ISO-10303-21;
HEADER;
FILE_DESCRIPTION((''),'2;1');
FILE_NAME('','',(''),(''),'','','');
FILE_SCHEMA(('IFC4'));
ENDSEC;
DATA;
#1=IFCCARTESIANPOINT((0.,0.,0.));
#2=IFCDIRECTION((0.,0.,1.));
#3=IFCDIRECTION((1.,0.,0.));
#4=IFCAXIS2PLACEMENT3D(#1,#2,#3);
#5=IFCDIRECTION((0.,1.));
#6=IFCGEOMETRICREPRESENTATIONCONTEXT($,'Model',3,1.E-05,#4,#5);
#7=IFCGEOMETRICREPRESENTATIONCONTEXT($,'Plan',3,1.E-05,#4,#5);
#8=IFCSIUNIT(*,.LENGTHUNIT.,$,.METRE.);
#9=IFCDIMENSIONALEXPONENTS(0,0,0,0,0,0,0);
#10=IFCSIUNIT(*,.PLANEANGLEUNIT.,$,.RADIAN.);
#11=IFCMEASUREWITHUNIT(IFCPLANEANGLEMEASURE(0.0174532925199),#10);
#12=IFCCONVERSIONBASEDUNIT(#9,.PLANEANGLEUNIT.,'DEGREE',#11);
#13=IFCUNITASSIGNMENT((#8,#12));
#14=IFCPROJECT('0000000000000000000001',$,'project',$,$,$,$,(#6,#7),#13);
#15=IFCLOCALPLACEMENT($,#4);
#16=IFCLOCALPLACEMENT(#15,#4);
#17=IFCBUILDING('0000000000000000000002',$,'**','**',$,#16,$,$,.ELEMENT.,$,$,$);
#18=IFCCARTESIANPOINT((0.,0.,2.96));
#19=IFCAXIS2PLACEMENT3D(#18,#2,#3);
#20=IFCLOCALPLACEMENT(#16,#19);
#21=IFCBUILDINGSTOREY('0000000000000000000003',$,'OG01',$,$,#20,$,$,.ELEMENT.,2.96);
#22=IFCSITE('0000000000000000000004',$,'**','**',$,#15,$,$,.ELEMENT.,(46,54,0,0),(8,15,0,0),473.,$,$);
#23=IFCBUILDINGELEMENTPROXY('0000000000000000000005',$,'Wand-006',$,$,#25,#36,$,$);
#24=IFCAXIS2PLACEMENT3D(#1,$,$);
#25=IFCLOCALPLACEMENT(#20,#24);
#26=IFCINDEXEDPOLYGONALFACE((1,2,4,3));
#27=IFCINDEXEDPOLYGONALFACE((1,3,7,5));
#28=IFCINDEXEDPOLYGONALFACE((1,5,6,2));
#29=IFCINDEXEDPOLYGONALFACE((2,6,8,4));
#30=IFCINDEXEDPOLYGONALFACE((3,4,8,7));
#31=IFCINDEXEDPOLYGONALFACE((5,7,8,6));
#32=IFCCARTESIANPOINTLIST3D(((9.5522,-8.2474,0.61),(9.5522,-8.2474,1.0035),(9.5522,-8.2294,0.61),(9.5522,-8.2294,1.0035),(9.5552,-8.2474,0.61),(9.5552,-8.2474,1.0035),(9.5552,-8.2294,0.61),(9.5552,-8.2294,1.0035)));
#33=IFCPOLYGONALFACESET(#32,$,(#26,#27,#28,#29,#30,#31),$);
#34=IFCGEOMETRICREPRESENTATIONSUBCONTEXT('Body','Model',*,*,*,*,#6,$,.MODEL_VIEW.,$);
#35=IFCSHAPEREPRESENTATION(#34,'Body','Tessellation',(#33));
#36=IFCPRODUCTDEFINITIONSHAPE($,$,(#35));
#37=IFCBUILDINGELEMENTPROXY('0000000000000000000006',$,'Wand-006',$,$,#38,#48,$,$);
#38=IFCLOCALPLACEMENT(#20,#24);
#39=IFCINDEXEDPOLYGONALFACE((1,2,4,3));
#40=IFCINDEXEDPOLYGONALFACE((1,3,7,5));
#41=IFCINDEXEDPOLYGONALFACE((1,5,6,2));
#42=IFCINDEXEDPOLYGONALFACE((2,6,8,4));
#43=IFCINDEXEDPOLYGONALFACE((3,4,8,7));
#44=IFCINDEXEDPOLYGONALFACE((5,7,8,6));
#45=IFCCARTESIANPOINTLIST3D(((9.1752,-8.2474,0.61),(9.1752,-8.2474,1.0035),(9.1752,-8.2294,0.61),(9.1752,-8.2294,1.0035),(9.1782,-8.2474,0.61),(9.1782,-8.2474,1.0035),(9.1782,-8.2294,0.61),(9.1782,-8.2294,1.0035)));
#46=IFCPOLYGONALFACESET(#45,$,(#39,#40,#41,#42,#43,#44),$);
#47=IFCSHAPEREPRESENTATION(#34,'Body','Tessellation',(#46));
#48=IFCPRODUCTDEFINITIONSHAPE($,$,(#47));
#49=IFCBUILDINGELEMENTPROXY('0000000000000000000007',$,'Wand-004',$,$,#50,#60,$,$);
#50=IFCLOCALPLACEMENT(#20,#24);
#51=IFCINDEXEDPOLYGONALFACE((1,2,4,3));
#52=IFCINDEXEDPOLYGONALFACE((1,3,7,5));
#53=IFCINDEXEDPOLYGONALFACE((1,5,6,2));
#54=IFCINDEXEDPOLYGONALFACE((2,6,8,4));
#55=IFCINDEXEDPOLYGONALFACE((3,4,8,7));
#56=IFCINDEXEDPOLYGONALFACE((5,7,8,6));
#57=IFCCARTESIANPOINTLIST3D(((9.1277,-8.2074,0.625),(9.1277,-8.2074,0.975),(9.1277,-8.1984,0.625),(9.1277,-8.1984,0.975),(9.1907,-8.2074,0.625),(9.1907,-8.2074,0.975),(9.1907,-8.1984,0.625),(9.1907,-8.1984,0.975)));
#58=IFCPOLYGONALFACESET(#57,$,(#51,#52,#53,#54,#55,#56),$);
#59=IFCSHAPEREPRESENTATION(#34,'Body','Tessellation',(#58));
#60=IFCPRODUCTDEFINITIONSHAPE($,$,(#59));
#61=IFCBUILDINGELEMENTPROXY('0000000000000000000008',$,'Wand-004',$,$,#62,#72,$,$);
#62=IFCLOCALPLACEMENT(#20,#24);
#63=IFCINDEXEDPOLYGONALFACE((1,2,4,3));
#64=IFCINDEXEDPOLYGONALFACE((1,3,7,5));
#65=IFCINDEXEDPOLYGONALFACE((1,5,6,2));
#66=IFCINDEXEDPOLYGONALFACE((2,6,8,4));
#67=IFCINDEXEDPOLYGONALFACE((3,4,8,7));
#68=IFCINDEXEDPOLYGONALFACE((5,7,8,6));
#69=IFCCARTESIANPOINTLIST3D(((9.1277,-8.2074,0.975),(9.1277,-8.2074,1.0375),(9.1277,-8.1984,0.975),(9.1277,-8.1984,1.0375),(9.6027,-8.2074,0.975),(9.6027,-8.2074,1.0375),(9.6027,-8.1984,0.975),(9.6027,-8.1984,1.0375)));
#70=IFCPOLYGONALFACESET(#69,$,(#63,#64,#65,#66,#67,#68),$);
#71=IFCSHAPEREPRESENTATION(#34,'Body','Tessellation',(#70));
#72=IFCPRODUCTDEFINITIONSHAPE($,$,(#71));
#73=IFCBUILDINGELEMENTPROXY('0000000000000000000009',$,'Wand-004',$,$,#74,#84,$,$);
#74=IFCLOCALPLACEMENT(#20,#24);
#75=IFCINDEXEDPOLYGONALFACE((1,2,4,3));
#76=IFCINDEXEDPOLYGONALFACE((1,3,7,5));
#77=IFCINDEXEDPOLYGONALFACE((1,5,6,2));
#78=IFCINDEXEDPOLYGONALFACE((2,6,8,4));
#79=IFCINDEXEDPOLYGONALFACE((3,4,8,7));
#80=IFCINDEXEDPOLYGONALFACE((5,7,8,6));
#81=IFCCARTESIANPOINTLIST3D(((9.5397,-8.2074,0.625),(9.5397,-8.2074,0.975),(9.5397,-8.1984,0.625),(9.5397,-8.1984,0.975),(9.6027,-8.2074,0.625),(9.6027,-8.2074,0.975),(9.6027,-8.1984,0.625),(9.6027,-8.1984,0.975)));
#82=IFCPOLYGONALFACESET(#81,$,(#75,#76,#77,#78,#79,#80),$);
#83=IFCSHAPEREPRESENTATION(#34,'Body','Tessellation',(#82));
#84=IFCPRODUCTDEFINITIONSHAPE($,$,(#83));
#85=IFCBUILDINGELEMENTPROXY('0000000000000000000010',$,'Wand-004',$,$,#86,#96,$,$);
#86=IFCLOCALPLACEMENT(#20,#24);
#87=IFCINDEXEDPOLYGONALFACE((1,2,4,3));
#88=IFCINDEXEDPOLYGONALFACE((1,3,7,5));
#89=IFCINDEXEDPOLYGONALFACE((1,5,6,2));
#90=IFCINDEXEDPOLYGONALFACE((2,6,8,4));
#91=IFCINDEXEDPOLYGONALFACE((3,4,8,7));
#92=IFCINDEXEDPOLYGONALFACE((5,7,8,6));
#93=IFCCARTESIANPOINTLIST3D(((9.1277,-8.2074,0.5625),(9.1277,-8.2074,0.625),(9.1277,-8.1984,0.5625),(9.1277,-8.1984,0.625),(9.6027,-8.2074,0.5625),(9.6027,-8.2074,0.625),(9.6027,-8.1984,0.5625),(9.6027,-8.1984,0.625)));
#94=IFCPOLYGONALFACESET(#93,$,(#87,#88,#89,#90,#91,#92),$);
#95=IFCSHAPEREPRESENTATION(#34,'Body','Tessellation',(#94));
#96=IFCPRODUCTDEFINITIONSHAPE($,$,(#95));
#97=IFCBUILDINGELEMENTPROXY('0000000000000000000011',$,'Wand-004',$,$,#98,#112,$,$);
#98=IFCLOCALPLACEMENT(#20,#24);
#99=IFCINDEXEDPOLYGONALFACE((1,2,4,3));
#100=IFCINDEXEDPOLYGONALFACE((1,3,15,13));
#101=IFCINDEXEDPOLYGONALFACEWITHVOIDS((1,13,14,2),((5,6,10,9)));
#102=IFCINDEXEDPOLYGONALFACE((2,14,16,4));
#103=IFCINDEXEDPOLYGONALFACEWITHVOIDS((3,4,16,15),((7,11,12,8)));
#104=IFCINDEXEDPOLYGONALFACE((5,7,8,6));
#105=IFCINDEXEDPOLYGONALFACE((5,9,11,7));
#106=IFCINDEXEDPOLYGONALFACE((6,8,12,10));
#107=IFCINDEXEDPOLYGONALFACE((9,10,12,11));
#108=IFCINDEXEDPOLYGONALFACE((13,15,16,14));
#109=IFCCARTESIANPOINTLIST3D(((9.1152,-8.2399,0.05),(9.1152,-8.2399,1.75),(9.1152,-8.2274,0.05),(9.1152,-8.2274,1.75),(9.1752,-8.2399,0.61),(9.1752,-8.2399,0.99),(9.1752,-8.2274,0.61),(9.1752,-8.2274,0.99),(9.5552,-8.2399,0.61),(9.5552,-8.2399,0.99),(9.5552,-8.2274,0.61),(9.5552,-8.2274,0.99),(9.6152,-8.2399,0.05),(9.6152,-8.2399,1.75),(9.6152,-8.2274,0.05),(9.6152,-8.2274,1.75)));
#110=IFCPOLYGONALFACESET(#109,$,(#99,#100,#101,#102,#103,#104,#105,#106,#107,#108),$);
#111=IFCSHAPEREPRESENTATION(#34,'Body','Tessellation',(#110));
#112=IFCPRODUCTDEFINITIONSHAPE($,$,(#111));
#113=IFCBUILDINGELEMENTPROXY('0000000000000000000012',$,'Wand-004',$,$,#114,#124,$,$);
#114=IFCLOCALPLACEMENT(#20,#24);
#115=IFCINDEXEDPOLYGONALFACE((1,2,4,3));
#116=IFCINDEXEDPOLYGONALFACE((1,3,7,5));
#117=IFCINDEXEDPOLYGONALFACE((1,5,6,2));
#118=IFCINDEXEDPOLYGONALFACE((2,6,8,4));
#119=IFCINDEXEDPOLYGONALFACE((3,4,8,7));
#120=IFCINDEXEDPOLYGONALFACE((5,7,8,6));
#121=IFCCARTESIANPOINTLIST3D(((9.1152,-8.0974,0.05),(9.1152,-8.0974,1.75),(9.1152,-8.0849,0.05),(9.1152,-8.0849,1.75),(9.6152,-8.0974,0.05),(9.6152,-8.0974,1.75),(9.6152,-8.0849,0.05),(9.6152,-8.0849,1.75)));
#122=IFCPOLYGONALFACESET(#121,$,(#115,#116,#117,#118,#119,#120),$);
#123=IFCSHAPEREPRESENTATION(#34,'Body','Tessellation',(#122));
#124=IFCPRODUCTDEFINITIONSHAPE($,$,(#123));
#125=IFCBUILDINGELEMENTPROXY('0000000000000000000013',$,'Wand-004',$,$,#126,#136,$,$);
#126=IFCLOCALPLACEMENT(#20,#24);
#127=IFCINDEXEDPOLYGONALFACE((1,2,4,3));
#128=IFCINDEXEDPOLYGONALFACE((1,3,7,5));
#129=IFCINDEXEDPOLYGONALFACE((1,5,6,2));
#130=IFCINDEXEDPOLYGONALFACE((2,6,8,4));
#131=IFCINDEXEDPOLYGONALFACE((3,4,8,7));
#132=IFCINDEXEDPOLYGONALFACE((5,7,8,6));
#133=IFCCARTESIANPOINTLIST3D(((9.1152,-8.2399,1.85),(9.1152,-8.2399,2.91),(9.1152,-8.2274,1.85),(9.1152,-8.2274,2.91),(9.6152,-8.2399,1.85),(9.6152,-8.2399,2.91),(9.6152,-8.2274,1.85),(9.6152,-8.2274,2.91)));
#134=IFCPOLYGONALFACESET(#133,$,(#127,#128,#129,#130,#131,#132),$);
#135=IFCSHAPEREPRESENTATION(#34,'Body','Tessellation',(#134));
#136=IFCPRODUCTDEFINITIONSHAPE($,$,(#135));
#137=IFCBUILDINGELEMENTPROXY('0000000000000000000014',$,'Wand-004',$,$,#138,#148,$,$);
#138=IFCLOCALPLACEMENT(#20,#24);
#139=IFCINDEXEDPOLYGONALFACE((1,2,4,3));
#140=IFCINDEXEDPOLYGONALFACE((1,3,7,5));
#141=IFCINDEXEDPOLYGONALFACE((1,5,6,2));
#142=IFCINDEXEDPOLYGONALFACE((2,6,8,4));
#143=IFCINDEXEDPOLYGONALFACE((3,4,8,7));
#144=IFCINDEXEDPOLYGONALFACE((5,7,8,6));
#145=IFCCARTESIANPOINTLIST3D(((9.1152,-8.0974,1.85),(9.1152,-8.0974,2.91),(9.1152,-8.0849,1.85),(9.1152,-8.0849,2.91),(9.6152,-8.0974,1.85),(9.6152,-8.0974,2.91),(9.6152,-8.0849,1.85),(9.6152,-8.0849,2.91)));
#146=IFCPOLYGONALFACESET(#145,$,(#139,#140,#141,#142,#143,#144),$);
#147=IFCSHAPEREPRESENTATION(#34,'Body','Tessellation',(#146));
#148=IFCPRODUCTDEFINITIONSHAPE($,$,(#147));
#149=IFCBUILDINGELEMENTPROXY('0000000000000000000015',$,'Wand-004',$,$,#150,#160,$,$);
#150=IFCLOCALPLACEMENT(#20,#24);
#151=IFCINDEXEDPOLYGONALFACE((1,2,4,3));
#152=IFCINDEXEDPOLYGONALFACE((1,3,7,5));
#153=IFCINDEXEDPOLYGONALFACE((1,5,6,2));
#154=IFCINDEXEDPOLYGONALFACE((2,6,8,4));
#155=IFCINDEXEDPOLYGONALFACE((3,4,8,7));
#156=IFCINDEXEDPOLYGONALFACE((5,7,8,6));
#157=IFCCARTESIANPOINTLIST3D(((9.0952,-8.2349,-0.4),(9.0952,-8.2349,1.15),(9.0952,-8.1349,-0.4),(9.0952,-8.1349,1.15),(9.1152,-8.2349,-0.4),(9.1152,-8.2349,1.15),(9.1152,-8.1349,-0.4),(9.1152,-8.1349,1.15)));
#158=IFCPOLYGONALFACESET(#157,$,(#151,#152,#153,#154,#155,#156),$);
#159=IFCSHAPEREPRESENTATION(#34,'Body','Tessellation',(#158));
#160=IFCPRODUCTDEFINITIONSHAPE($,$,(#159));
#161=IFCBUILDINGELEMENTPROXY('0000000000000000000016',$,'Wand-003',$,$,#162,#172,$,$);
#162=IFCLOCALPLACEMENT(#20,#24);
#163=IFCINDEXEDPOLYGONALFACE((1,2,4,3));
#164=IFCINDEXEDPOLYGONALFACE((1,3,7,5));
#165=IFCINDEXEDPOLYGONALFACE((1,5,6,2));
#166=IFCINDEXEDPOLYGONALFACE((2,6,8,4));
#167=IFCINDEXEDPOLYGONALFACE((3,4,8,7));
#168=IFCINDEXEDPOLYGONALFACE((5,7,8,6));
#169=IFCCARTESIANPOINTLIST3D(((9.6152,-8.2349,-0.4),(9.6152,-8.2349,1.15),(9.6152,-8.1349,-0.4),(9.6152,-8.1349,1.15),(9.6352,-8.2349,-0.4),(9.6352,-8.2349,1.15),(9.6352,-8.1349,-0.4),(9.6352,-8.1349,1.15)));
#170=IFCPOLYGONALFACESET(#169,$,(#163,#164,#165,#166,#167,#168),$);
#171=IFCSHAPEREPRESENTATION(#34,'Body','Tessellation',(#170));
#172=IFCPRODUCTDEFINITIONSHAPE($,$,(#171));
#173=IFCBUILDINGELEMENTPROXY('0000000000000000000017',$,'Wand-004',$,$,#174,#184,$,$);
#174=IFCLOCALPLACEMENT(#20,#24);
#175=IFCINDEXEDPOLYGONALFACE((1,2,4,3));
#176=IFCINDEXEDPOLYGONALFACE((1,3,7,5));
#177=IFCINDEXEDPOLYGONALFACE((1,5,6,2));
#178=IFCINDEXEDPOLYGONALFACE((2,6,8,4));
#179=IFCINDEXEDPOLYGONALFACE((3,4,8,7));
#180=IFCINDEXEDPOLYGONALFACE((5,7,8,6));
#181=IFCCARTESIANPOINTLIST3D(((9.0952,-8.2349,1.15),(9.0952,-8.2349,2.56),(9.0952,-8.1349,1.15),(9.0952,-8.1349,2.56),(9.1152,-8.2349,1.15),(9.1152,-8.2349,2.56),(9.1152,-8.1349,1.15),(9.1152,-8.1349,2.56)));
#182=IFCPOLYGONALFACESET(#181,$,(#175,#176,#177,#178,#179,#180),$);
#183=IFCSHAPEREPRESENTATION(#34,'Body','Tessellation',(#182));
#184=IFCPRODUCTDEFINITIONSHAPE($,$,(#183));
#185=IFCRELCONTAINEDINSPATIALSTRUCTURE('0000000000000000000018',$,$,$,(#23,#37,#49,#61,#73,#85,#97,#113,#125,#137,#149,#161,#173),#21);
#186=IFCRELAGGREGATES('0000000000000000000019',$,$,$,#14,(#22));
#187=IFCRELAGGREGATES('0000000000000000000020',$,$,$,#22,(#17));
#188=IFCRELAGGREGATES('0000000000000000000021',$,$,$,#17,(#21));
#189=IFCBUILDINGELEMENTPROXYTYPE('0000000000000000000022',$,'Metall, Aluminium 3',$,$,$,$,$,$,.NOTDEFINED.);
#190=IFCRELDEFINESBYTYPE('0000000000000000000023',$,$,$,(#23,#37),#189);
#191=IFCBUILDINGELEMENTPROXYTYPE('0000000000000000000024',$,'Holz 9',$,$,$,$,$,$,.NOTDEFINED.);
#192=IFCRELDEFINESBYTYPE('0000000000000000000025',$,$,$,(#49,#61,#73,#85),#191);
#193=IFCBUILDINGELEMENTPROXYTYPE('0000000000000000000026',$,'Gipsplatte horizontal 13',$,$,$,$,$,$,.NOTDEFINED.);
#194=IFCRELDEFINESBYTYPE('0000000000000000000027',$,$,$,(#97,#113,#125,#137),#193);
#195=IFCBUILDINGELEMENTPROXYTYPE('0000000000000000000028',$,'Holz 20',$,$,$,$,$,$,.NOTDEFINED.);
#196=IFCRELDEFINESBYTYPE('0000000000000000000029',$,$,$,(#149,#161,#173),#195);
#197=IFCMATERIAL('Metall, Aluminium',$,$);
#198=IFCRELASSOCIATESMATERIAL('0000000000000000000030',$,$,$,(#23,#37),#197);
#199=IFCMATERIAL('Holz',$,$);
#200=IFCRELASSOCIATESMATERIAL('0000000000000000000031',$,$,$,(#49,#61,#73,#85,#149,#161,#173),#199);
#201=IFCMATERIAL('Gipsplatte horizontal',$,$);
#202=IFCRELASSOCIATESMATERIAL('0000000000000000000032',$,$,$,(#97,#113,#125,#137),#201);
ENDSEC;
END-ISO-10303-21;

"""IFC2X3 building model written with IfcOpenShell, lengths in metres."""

from ifc_helpers import new_model, entity, si_unit, converted_unit, direction, frame, origin_with_axes, origin_2d_with_axis, place, context, subcontext, project, spatial, polyline, rectangle, outline, extrude, material, type_object, element, save


model = new_model("IFC2X3")

# Units and contexts
model_context = context("Model", 3, precision=1e-05, world=origin_with_axes(), true_north=direction((0.0, 1.0)))
plan_context = context("Plan", 3, precision=1e-05, world=origin_with_axes(), true_north=direction((0.0, 1.0)))
body_context = subcontext(model_context, "Body", "Model", "MODEL_VIEW")
ifc_project = project(units=[si_unit("LENGTHUNIT", "METRE"), converted_unit("PLANEANGLEUNIT", "DEGREE", entity("IfcPlaneAngleMeasure", 0.0174532925199), si_unit("PLANEANGLEUNIT", "RADIAN"), dimensions=[0, 0, 0, 0, 0, 0, 0])], contexts=[model_context, plan_context])

# Site, building, storey
site_placement = place(None, origin_with_axes())
site = spatial("IfcSite", under=ifc_project, at=site_placement, Name="**", Description="**", CompositionType="ELEMENT", RefLatitude=(46, 54, 0, 0), RefLongitude=(8, 15, 0, 0), RefElevation=473.0)
building_placement = place(site_placement, origin_with_axes())
building = spatial("IfcBuilding", under=site, at=building_placement, Name="**", Description="**", CompositionType="ELEMENT")
storey_placement = place(building_placement, frame((0.0, 0.0, 2.96), z_axis=(0.0, 0.0, 1.0), x_axis=(1.0, 0.0, 0.0)))
storey = spatial("IfcBuildingStorey", under=building, at=storey_placement, Name="OG01", CompositionType="ELEMENT", Elevation=2.96)

# Building element proxies
ifc_material_1 = material(Name="Holz")
ifc_material_2 = material(Name="Metall, Aluminium")
building_element_proxy_type_1 = type_object("IfcBuildingElementProxyType", Name="Metall, Aluminium 3", PredefinedType="NOTDEFINED")
proxy_1_placement = place(storey_placement, frame((9.5552, -8.2294, 0.61), z_axis=(0.0, 0.0, 1.0), x_axis=(0.0, -1.0, 0.0)))
element("IfcBuildingElementProxy", 1, at=proxy_1_placement, inside=storey, type_object=building_element_proxy_type_1, material=ifc_material_2, Name="Wand-006", context=body_context, shape_type="SweptSolid", body=[
    extrude(outline(polyline([(0.0, -0.003), (0.018, -0.003), (0.018, 0.0), (0.0, 0.0), (0.0, -0.003)])), origin_with_axes(), (0.0, 0.0, 1.0), 0.3935),
])
proxy_2_placement = place(storey_placement, frame((9.1752, -8.2294, 0.61), z_axis=(0.0, 0.0, 1.0), x_axis=(0.0, -1.0, 0.0)))
element("IfcBuildingElementProxy", 2, at=proxy_2_placement, inside=storey, type_object=building_element_proxy_type_1, material=ifc_material_2, Name="Wand-006", context=body_context, shape_type="SweptSolid", body=[
    extrude(outline(polyline([(0.0, 0.0), (0.018, 0.0), (0.018, 0.003), (0.0, 0.003), (0.0, 0.0)])), origin_with_axes(), (0.0, 0.0, 1.0), 0.3935),
])
building_element_proxy_type_2 = type_object("IfcBuildingElementProxyType", Name="Holz 9", PredefinedType="NOTDEFINED")
proxy_3_placement = place(storey_placement, frame((9.1277, -8.2074, 0.625), z_axis=(0.0, 0.0, 1.0), x_axis=(1.0, 0.0, 0.0)))
element("IfcBuildingElementProxy", 3, at=proxy_3_placement, inside=storey, type_object=building_element_proxy_type_2, material=ifc_material_1, Name="Wand-004", context=body_context, shape_type="SweptSolid", body=[
    extrude(outline(polyline([(0.0, 0.0), (0.063, 0.0), (0.063, 0.009), (0.0, 0.009), (0.0, 0.0)])), origin_with_axes(), (0.0, 0.0, 1.0), 0.35),
])
proxy_4_placement = place(storey_placement, frame((9.6027, -8.2074, 0.975), z_axis=(0.0, 0.0, 1.0), x_axis=(-1.0, 0.0, 0.0)))
element("IfcBuildingElementProxy", 4, at=proxy_4_placement, inside=storey, type_object=building_element_proxy_type_2, material=ifc_material_1, Name="Wand-004", context=body_context, shape_type="SweptSolid", body=[
    extrude(outline(polyline([(0.0, -0.009), (0.475, -0.009), (0.475, 0.0), (0.0, 0.0), (0.0, -0.009)])), origin_with_axes(), (0.0, 0.0, 1.0), 0.0625),
])
proxy_5_placement = place(storey_placement, frame((9.5397, -8.2074, 0.625), z_axis=(0.0, 0.0, 1.0), x_axis=(1.0, 0.0, 0.0)))
element("IfcBuildingElementProxy", 5, at=proxy_5_placement, inside=storey, type_object=building_element_proxy_type_2, material=ifc_material_1, Name="Wand-004", context=body_context, shape_type="SweptSolid", body=[
    extrude(outline(polyline([(0.0, 0.0), (0.063, 0.0), (0.063, 0.009), (0.0, 0.009), (0.0, 0.0)])), origin_with_axes(), (0.0, 0.0, 1.0), 0.35),
])
proxy_6_placement = place(storey_placement, frame((9.6027, -8.2074, 0.5625), z_axis=(0.0, 0.0, 1.0), x_axis=(-1.0, 0.0, 0.0)))
element("IfcBuildingElementProxy", 6, at=proxy_6_placement, inside=storey, type_object=building_element_proxy_type_2, material=ifc_material_1, Name="Wand-004", context=body_context, shape_type="SweptSolid", body=[
    extrude(outline(polyline([(0.0, -0.009), (0.475, -0.009), (0.475, 0.0), (0.0, 0.0), (0.0, -0.009)])), origin_with_axes(), (0.0, 0.0, 1.0), 0.0625),
])

# Building element proxy, opening
ifc_material_3 = material(Name="Gipsplatte horizontal")
building_element_proxy_type_3 = type_object("IfcBuildingElementProxyType", Name="Gipsplatte horizontal 13", PredefinedType="NOTDEFINED")
proxy_7_placement = place(storey_placement, frame((9.1152, -8.2399, 0.05), z_axis=(0.0, 0.0, 1.0), x_axis=(1.0, 0.0, 0.0)))
proxy_7 = element("IfcBuildingElementProxy", 7, at=proxy_7_placement, inside=storey, type_object=building_element_proxy_type_3, material=ifc_material_3, Name="Wand-004", context=body_context, shape_type="SweptSolid", body=[
    extrude(outline(polyline([(0.0, 0.0), (0.5, 0.0), (0.5, 0.0125), (0.0, 0.0125), (0.0, 0.0)])), origin_with_axes(), (0.0, 0.0, 1.0), 1.7),
])
opening_placement = place(proxy_7_placement, frame((-9.1152, 8.2399, -3.01), z_axis=(0.0, 0.0, 1.0), x_axis=(1.0, 0.0, 0.0)))
element("IfcOpeningElement", 8, at=opening_placement, cuts=proxy_7, context=body_context, shape_type="SweptSolid", body=[
    extrude(rectangle(XDim=0.38, YDim=0.38, at=origin_2d_with_axis()), frame((9.3652, -8.2524, 3.76), z_axis=(0.0, -1.0, 0.0), x_axis=(1.0, 0.0, 0.0)), (0.0, 0.0, -1.0), 0.0375),
])

# Building element proxies
proxy_8_placement = place(storey_placement, frame((9.1152, -8.0849, 0.05), z_axis=(0.0, 0.0, 1.0), x_axis=(1.0, 0.0, 0.0)))
element("IfcBuildingElementProxy", 9, at=proxy_8_placement, inside=storey, type_object=building_element_proxy_type_3, material=ifc_material_3, Name="Wand-004", context=body_context, shape_type="SweptSolid", body=[
    extrude(outline(polyline([(0.0, -0.0125), (0.5, -0.0125), (0.5, 0.0), (0.0, 0.0), (0.0, -0.0125)])), origin_with_axes(), (0.0, 0.0, 1.0), 1.7),
])
proxy_9_placement = place(storey_placement, frame((9.1152, -8.2399, 1.85), z_axis=(0.0, 0.0, 1.0), x_axis=(1.0, 0.0, 0.0)))
element("IfcBuildingElementProxy", 10, at=proxy_9_placement, inside=storey, type_object=building_element_proxy_type_3, material=ifc_material_3, Name="Wand-004", context=body_context, shape_type="SweptSolid", body=[
    extrude(outline(polyline([(0.0, 0.0), (0.5, 0.0), (0.5, 0.0125), (0.0, 0.0125), (0.0, 0.0)])), origin_with_axes(), (0.0, 0.0, 1.0), 1.06),
])
proxy_10_placement = place(storey_placement, frame((9.1152, -8.0849, 1.85), z_axis=(0.0, 0.0, 1.0), x_axis=(1.0, 0.0, 0.0)))
element("IfcBuildingElementProxy", 11, at=proxy_10_placement, inside=storey, type_object=building_element_proxy_type_3, material=ifc_material_3, Name="Wand-004", context=body_context, shape_type="SweptSolid", body=[
    extrude(outline(polyline([(0.0, -0.0125), (0.5, -0.0125), (0.5, 0.0), (0.0, 0.0), (0.0, -0.0125)])), origin_with_axes(), (0.0, 0.0, 1.0), 1.06),
])
building_element_proxy_type_4 = type_object("IfcBuildingElementProxyType", Name="Holz 20", PredefinedType="NOTDEFINED")
proxy_11_placement = place(storey_placement, frame((9.0952, -8.1349, -0.4), z_axis=(0.0, 0.0, 1.0), x_axis=(0.0, -1.0, 0.0)))
element("IfcBuildingElementProxy", 12, at=proxy_11_placement, inside=storey, type_object=building_element_proxy_type_4, material=ifc_material_1, Name="Wand-004", context=body_context, shape_type="SweptSolid", body=[
    extrude(outline(polyline([(0.0, 0.0), (0.1, 0.0), (0.1, 0.02), (0.0, 0.02), (0.0, 0.0)])), origin_with_axes(), (0.0, 0.0, 1.0), 1.55),
])
proxy_12_placement = place(storey_placement, frame((9.6352, -8.1349, -0.4), z_axis=(0.0, 0.0, 1.0), x_axis=(0.0, -1.0, 0.0)))
element("IfcBuildingElementProxy", 13, at=proxy_12_placement, inside=storey, type_object=building_element_proxy_type_4, material=ifc_material_1, Name="Wand-003", context=body_context, shape_type="SweptSolid", body=[
    extrude(outline(polyline([(0.0, -0.02), (0.1, -0.02), (0.1, 0.0), (0.0, 0.0), (0.0, -0.02)])), origin_with_axes(), (0.0, 0.0, 1.0), 1.55),
])
proxy_13_placement = place(storey_placement, frame((9.0952, -8.1349, 1.15), z_axis=(0.0, 0.0, 1.0), x_axis=(0.0, -1.0, 0.0)))
element("IfcBuildingElementProxy", 14, at=proxy_13_placement, inside=storey, type_object=building_element_proxy_type_4, material=ifc_material_1, Name="Wand-004", context=body_context, shape_type="SweptSolid", body=[
    extrude(outline(polyline([(0.0, 0.0), (0.1, 0.0), (0.1, 0.02), (0.0, 0.02), (0.0, 0.0)])), origin_with_axes(), (0.0, 0.0, 1.0), 1.41),
])

save(model, "model.ifc")
